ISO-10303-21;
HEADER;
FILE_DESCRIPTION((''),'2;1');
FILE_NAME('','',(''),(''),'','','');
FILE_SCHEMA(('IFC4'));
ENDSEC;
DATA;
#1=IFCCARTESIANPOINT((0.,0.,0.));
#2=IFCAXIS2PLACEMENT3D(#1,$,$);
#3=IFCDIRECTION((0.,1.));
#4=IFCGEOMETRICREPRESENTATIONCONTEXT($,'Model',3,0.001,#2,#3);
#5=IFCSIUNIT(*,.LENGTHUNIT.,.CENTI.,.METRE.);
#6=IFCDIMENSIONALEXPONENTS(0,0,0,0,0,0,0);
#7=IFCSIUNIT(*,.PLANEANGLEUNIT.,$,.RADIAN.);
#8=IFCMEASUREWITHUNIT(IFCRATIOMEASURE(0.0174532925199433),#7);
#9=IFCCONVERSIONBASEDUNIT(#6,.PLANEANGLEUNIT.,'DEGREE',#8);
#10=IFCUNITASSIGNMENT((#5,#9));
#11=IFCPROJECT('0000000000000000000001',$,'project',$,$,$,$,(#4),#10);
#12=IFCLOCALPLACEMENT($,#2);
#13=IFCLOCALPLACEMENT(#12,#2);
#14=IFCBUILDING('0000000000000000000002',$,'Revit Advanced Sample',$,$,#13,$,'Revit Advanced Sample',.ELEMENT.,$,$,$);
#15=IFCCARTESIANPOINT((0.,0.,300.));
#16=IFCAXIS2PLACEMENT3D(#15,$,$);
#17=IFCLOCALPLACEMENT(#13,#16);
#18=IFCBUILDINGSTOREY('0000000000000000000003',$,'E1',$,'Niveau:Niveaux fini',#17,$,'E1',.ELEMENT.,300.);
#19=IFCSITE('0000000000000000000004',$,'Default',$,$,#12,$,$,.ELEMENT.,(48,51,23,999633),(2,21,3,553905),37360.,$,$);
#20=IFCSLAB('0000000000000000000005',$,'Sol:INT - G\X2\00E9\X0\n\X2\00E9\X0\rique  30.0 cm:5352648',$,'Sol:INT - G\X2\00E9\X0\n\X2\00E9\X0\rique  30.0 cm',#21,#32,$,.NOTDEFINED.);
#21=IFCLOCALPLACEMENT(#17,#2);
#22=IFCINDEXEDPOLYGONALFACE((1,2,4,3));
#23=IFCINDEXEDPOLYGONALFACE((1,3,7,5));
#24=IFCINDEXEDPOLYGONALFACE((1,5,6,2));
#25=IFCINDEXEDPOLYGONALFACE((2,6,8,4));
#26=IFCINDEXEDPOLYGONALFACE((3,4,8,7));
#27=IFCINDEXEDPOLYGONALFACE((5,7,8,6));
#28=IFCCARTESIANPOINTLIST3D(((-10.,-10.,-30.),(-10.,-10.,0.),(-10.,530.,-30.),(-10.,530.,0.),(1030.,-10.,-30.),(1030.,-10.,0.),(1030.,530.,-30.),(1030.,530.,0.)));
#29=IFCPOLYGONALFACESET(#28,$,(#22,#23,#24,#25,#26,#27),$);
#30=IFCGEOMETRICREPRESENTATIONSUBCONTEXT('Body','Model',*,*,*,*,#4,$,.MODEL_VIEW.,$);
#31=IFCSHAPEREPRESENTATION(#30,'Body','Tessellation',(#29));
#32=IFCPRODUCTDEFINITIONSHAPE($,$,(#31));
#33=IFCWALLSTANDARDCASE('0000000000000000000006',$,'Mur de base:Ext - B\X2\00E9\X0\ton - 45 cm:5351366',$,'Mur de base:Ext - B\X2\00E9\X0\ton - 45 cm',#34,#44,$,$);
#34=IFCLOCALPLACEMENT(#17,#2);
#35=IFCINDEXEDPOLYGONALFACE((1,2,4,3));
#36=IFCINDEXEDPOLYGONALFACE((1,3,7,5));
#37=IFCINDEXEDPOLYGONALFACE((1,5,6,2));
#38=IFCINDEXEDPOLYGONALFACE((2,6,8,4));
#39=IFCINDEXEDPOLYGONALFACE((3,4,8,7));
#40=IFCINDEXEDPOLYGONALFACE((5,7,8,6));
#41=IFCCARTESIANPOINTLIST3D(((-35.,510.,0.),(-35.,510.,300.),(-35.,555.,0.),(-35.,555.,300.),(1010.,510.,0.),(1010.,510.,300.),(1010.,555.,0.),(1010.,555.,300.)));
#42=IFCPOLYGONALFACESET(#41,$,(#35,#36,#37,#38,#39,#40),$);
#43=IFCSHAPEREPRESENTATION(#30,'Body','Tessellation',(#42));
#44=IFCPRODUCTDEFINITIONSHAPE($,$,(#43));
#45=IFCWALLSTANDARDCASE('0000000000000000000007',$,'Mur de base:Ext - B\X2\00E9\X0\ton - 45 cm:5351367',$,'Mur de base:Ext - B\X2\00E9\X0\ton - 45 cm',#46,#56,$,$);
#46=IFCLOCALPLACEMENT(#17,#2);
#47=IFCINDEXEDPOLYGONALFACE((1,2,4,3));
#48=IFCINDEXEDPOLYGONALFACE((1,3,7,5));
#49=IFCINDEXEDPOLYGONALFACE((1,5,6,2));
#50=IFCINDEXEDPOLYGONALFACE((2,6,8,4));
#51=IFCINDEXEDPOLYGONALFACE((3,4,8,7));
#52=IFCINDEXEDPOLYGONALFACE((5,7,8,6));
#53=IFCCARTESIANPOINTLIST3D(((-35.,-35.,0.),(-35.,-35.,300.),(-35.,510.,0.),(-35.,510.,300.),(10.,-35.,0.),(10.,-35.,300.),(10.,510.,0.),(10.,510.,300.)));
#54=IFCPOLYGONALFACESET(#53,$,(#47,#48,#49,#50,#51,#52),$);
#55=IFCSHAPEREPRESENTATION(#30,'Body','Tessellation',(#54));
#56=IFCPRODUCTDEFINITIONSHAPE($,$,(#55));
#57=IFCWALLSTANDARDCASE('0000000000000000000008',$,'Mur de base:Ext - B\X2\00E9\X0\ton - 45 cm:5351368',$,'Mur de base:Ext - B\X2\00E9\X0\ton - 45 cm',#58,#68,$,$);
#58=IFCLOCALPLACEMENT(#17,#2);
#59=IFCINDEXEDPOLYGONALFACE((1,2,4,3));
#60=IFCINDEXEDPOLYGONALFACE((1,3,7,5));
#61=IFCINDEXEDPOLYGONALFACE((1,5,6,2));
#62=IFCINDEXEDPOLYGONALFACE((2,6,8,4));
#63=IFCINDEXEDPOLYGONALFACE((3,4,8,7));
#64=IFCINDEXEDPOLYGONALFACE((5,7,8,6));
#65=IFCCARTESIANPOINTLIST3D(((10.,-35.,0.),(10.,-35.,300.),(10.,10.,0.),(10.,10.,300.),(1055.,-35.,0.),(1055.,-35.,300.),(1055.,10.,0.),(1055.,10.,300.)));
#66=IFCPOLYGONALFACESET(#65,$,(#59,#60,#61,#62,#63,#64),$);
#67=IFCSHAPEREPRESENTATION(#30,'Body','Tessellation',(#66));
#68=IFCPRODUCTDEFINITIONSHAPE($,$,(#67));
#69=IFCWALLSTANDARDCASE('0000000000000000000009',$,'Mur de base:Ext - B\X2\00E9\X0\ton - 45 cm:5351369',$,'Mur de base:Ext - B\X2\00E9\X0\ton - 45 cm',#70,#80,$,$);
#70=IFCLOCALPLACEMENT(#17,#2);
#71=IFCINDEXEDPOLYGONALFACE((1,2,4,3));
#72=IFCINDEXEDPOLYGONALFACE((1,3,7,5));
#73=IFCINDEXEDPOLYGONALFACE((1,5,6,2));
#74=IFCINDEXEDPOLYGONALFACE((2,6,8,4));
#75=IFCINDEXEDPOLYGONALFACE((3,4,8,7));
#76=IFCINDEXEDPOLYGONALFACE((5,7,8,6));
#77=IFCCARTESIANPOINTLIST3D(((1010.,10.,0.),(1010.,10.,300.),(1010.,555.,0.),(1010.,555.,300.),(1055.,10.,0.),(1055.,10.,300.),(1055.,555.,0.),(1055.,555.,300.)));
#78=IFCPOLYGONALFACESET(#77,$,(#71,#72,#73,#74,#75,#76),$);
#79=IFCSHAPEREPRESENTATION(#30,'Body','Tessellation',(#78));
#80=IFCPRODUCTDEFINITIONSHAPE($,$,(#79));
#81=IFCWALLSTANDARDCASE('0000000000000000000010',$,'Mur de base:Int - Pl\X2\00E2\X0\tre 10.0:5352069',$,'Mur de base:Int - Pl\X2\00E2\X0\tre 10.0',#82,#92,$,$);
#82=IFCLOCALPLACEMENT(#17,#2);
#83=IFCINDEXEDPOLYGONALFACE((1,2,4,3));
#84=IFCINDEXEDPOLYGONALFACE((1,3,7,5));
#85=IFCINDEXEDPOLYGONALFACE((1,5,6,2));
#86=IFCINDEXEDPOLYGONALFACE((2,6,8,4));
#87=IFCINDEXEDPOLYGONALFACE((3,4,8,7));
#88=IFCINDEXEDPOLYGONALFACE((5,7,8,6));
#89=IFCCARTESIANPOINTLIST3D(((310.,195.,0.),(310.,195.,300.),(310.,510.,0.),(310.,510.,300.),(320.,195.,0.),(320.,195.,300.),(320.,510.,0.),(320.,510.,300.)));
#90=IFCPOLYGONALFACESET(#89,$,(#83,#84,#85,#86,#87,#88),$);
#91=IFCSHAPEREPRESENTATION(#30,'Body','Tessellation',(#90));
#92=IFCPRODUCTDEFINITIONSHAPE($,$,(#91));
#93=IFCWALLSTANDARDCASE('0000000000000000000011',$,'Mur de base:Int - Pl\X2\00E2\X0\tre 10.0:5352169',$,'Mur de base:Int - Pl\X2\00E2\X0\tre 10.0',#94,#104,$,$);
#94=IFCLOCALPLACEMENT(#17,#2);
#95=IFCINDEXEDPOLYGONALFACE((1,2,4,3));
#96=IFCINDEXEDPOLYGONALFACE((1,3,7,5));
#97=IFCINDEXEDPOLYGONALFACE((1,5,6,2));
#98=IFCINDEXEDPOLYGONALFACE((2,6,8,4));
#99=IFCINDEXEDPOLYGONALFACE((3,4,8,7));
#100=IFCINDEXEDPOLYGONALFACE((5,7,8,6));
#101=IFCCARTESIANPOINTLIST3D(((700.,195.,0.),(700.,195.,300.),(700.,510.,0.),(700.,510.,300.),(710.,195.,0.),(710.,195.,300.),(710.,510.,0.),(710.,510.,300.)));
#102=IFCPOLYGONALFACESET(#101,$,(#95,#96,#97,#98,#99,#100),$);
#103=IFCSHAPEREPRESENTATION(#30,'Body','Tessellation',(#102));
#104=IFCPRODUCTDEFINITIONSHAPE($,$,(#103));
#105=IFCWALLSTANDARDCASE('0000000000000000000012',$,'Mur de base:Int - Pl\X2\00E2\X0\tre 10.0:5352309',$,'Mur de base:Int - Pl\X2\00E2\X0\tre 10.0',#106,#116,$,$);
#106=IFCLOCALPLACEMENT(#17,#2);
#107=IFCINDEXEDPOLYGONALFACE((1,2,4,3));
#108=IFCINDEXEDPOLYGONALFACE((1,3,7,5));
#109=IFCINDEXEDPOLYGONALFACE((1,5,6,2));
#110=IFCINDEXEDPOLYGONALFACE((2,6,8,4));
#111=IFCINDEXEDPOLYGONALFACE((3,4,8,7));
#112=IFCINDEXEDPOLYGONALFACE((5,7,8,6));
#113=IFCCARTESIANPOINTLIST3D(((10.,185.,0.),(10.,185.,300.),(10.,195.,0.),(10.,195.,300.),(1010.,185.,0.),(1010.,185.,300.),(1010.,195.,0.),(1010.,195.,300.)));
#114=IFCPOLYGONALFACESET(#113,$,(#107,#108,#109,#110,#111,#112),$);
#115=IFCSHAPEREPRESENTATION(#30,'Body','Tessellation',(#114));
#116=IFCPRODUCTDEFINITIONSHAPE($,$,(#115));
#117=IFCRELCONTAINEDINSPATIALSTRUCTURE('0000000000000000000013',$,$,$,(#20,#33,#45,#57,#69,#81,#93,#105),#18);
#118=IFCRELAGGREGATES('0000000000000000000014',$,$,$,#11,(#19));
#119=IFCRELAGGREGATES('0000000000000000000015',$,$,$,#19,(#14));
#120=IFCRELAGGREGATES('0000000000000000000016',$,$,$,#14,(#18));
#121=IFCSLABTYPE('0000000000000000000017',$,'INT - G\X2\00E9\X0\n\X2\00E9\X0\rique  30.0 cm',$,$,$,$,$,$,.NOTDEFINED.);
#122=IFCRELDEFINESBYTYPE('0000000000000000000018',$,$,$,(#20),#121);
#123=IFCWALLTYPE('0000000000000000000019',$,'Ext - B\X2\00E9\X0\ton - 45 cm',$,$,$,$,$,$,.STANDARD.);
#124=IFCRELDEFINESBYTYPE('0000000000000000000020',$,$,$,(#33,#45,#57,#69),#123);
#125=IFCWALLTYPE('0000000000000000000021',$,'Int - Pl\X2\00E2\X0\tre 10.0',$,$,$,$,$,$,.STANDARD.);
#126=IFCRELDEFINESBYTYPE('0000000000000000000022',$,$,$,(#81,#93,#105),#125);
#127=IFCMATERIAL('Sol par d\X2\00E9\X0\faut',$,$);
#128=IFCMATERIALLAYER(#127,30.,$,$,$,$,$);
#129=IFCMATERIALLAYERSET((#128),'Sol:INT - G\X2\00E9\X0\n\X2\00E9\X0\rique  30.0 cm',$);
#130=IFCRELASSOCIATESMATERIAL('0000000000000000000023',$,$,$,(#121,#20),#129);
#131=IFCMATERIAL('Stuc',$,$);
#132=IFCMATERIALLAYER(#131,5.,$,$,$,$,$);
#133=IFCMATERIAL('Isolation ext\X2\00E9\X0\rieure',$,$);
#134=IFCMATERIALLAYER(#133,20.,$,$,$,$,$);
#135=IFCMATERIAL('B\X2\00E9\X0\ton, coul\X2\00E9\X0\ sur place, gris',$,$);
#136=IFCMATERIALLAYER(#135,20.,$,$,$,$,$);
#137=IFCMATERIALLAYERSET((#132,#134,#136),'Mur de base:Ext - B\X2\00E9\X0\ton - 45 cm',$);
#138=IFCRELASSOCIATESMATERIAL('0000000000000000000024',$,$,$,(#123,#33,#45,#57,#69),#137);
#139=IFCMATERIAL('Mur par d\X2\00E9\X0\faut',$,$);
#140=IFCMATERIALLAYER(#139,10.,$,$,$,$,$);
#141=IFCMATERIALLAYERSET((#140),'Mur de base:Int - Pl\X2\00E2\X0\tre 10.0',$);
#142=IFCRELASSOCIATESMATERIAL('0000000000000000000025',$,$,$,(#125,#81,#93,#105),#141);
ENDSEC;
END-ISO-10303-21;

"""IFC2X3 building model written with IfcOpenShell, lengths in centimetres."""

from ifc_helpers import new_model, entity, si_unit, converted_unit, direction, frame, frame_2d, origin, place, context, subcontext, project, spatial, rectangle, extrude, material, layer, layer_set, layer_usage, type_object, element, save


model = new_model("IFC2X3")

# Units and contexts
model_context = context("Model", 3, precision=0.001, world=origin(), true_north=direction((0.0, 1.0)))
body_context = subcontext(model_context, "Body", "Model", "MODEL_VIEW")
ifc_project = project(units=[si_unit("LENGTHUNIT", "METRE", prefix="CENTI"), converted_unit("PLANEANGLEUNIT", "DEGREE", entity("IfcRatioMeasure", 0.0174532925199433), si_unit("PLANEANGLEUNIT", "RADIAN"), dimensions=[0, 0, 0, 0, 0, 0, 0])], contexts=[model_context])

# Site, building, storey
site_placement = place(None, origin())
site = spatial("IfcSite", under=ifc_project, at=site_placement, Name="Default", CompositionType="ELEMENT", RefLatitude=(48, 51, 23, 999633), RefLongitude=(2, 21, 3, 553905), RefElevation=37360.0)
building_placement = place(site_placement, origin())
building = spatial("IfcBuilding", under=site, at=building_placement, Name="Revit Advanced Sample", LongName="Revit Advanced Sample", CompositionType="ELEMENT")
storey_placement = place(building_placement, frame((0.0, 0.0, 300.0)))
storey = spatial("IfcBuildingStorey", under=building, at=storey_placement, Name="E1", ObjectType="Niveau:Niveaux fini", LongName="E1", CompositionType="ELEMENT", Elevation=300.0)

# Slab
ifc_material_1 = material(Name="Sol par défaut")
ifc_layer_1 = layer(ifc_material_1, 30.0)
ifc_layer_set_1 = layer_set([ifc_layer_1], Name="Sol:INT - Générique  30.0 cm")
ifc_layer_usage_1 = layer_usage(ifc_layer_set_1, "AXIS3", "POSITIVE", 0.0)
slab_type = type_object("IfcSlabType", Name="INT - Générique  30.0 cm", PredefinedType="NOTDEFINED", material=ifc_layer_set_1)
slab_placement = place(storey_placement, origin())
element("IfcSlab", 1, at=slab_placement, inside=storey, type_object=slab_type, material=ifc_layer_usage_1, Name="Sol:INT - Générique  30.0 cm:5352648", ObjectType="Sol:INT - Générique  30.0 cm", PredefinedType="NOTDEFINED", context=body_context, shape_type="SweptSolid", body=[
    extrude(rectangle(XDim=540.0, YDim=1040.0, at=frame_2d((0.0, 0.0), x_axis=(1.0, 0.0))), frame((510.0, 260.0, 0.0), z_axis=(0.0, 0.0, -1.0), x_axis=(0.0, 1.0, 0.0)), (0.0, 0.0, 1.0), 30.0),
])

# Walls
ifc_material_2 = material(Name="Stuc")
ifc_layer_2 = layer(ifc_material_2, 5.0)
ifc_material_3 = material(Name="Isolation extérieure")
ifc_layer_3 = layer(ifc_material_3, 20.0)
ifc_material_4 = material(Name="Béton, coulé sur place, gris")
ifc_layer_4 = layer(ifc_material_4, 20.0)
ifc_layer_set_2 = layer_set([ifc_layer_2, ifc_layer_3, ifc_layer_4], Name="Mur de base:Ext - Béton - 45 cm")
ifc_layer_usage_2 = layer_usage(ifc_layer_set_2, "AXIS2", "NEGATIVE", 22.5)
wall_type_1 = type_object("IfcWallType", Name="Ext - Béton - 45 cm", PredefinedType="STANDARD", material=ifc_layer_set_2)
wall_1_placement = place(storey_placement, frame((-35.0, 532.5, 0.0)))
element("IfcWallStandardCase", 2, at=wall_1_placement, inside=storey, type_object=wall_type_1, material=ifc_layer_usage_2, Name="Mur de base:Ext - Béton - 45 cm:5351366", ObjectType="Mur de base:Ext - Béton - 45 cm", context=body_context, shape_type="SweptSolid", body=[
    extrude(rectangle(XDim=1045.0, YDim=45.0, at=frame_2d((522.5, 0.0), x_axis=(-1.0, 0.0))), origin(), (0.0, 0.0, 1.0), 300.0),
])
ifc_layer_usage_3 = layer_usage(ifc_layer_set_2, "AXIS2", "NEGATIVE", 22.5)
wall_2_placement = place(storey_placement, frame((-12.5, -35.0, 0.0), z_axis=(0.0, 0.0, 1.0), x_axis=(0.0, 1.0, 0.0)))
element("IfcWallStandardCase", 3, at=wall_2_placement, inside=storey, type_object=wall_type_1, material=ifc_layer_usage_3, Name="Mur de base:Ext - Béton - 45 cm:5351367", ObjectType="Mur de base:Ext - Béton - 45 cm", context=body_context, shape_type="SweptSolid", body=[
    extrude(rectangle(XDim=545.0, YDim=45.0, at=frame_2d((272.5, 0.0), x_axis=(-1.0, 0.0))), origin(), (0.0, 0.0, 1.0), 300.0),
])
ifc_layer_usage_4 = layer_usage(ifc_layer_set_2, "AXIS2", "NEGATIVE", 22.5)
wall_3_placement = place(storey_placement, frame((1055.0, -12.5, 0.0), z_axis=(0.0, 0.0, 1.0), x_axis=(-1.0, 0.0, 0.0)))
element("IfcWallStandardCase", 4, at=wall_3_placement, inside=storey, type_object=wall_type_1, material=ifc_layer_usage_4, Name="Mur de base:Ext - Béton - 45 cm:5351368", ObjectType="Mur de base:Ext - Béton - 45 cm", context=body_context, shape_type="SweptSolid", body=[
    extrude(rectangle(XDim=1045.0, YDim=45.0, at=frame_2d((522.5, 0.0), x_axis=(-1.0, 0.0))), origin(), (0.0, 0.0, 1.0), 300.0),
])
ifc_layer_usage_5 = layer_usage(ifc_layer_set_2, "AXIS2", "NEGATIVE", 22.5)
wall_4_placement = place(storey_placement, frame((1032.5, 555.0, 0.0), z_axis=(0.0, 0.0, 1.0), x_axis=(0.0, -1.0, 0.0)))
element("IfcWallStandardCase", 5, at=wall_4_placement, inside=storey, type_object=wall_type_1, material=ifc_layer_usage_5, Name="Mur de base:Ext - Béton - 45 cm:5351369", ObjectType="Mur de base:Ext - Béton - 45 cm", context=body_context, shape_type="SweptSolid", body=[
    extrude(rectangle(XDim=545.0, YDim=45.0, at=frame_2d((272.5, 0.0), x_axis=(-1.0, 0.0))), origin(), (0.0, 0.0, 1.0), 300.0),
])
ifc_material_5 = material(Name="Mur par défaut")
ifc_layer_5 = layer(ifc_material_5, 10.0)
ifc_layer_set_3 = layer_set([ifc_layer_5], Name="Mur de base:Int - Plâtre 10.0")
ifc_layer_usage_6 = layer_usage(ifc_layer_set_3, "AXIS2", "NEGATIVE", 5.0)
wall_type_2 = type_object("IfcWallType", Name="Int - Plâtre 10.0", PredefinedType="STANDARD", material=ifc_layer_set_3)
wall_5_placement = place(storey_placement, frame((315.0, 510.0, 0.0), z_axis=(0.0, 0.0, 1.0), x_axis=(0.0, -1.0, 0.0)))
element("IfcWallStandardCase", 6, at=wall_5_placement, inside=storey, type_object=wall_type_2, material=ifc_layer_usage_6, Name="Mur de base:Int - Plâtre 10.0:5352069", ObjectType="Mur de base:Int - Plâtre 10.0", context=body_context, shape_type="SweptSolid", body=[
    extrude(rectangle(XDim=315.0, YDim=10.0, at=frame_2d((157.5, 0.0), x_axis=(-1.0, 0.0))), origin(), (0.0, 0.0, 1.0), 300.0),
])
ifc_layer_usage_7 = layer_usage(ifc_layer_set_3, "AXIS2", "NEGATIVE", 5.0)
wall_6_placement = place(storey_placement, frame((705.0, 510.0, 0.0), z_axis=(0.0, 0.0, 1.0), x_axis=(0.0, -1.0, 0.0)))
element("IfcWallStandardCase", 7, at=wall_6_placement, inside=storey, type_object=wall_type_2, material=ifc_layer_usage_7, Name="Mur de base:Int - Plâtre 10.0:5352169", ObjectType="Mur de base:Int - Plâtre 10.0", context=body_context, shape_type="SweptSolid", body=[
    extrude(rectangle(XDim=315.0, YDim=10.0, at=frame_2d((157.5, 0.0), x_axis=(-1.0, 0.0))), origin(), (0.0, 0.0, 1.0), 300.0),
])
ifc_layer_usage_8 = layer_usage(ifc_layer_set_3, "AXIS2", "NEGATIVE", 5.0)
wall_7_placement = place(storey_placement, frame((10.0, 190.0, 0.0)))
element("IfcWallStandardCase", 8, at=wall_7_placement, inside=storey, type_object=wall_type_2, material=ifc_layer_usage_8, Name="Mur de base:Int - Plâtre 10.0:5352309", ObjectType="Mur de base:Int - Plâtre 10.0", context=body_context, shape_type="SweptSolid", body=[
    extrude(rectangle(XDim=1000.0, YDim=10.0, at=frame_2d((500.0, 0.0), x_axis=(-1.0, 0.0))), origin(), (0.0, 0.0, 1.0), 300.0),
])

save(model, "model.ifc")
